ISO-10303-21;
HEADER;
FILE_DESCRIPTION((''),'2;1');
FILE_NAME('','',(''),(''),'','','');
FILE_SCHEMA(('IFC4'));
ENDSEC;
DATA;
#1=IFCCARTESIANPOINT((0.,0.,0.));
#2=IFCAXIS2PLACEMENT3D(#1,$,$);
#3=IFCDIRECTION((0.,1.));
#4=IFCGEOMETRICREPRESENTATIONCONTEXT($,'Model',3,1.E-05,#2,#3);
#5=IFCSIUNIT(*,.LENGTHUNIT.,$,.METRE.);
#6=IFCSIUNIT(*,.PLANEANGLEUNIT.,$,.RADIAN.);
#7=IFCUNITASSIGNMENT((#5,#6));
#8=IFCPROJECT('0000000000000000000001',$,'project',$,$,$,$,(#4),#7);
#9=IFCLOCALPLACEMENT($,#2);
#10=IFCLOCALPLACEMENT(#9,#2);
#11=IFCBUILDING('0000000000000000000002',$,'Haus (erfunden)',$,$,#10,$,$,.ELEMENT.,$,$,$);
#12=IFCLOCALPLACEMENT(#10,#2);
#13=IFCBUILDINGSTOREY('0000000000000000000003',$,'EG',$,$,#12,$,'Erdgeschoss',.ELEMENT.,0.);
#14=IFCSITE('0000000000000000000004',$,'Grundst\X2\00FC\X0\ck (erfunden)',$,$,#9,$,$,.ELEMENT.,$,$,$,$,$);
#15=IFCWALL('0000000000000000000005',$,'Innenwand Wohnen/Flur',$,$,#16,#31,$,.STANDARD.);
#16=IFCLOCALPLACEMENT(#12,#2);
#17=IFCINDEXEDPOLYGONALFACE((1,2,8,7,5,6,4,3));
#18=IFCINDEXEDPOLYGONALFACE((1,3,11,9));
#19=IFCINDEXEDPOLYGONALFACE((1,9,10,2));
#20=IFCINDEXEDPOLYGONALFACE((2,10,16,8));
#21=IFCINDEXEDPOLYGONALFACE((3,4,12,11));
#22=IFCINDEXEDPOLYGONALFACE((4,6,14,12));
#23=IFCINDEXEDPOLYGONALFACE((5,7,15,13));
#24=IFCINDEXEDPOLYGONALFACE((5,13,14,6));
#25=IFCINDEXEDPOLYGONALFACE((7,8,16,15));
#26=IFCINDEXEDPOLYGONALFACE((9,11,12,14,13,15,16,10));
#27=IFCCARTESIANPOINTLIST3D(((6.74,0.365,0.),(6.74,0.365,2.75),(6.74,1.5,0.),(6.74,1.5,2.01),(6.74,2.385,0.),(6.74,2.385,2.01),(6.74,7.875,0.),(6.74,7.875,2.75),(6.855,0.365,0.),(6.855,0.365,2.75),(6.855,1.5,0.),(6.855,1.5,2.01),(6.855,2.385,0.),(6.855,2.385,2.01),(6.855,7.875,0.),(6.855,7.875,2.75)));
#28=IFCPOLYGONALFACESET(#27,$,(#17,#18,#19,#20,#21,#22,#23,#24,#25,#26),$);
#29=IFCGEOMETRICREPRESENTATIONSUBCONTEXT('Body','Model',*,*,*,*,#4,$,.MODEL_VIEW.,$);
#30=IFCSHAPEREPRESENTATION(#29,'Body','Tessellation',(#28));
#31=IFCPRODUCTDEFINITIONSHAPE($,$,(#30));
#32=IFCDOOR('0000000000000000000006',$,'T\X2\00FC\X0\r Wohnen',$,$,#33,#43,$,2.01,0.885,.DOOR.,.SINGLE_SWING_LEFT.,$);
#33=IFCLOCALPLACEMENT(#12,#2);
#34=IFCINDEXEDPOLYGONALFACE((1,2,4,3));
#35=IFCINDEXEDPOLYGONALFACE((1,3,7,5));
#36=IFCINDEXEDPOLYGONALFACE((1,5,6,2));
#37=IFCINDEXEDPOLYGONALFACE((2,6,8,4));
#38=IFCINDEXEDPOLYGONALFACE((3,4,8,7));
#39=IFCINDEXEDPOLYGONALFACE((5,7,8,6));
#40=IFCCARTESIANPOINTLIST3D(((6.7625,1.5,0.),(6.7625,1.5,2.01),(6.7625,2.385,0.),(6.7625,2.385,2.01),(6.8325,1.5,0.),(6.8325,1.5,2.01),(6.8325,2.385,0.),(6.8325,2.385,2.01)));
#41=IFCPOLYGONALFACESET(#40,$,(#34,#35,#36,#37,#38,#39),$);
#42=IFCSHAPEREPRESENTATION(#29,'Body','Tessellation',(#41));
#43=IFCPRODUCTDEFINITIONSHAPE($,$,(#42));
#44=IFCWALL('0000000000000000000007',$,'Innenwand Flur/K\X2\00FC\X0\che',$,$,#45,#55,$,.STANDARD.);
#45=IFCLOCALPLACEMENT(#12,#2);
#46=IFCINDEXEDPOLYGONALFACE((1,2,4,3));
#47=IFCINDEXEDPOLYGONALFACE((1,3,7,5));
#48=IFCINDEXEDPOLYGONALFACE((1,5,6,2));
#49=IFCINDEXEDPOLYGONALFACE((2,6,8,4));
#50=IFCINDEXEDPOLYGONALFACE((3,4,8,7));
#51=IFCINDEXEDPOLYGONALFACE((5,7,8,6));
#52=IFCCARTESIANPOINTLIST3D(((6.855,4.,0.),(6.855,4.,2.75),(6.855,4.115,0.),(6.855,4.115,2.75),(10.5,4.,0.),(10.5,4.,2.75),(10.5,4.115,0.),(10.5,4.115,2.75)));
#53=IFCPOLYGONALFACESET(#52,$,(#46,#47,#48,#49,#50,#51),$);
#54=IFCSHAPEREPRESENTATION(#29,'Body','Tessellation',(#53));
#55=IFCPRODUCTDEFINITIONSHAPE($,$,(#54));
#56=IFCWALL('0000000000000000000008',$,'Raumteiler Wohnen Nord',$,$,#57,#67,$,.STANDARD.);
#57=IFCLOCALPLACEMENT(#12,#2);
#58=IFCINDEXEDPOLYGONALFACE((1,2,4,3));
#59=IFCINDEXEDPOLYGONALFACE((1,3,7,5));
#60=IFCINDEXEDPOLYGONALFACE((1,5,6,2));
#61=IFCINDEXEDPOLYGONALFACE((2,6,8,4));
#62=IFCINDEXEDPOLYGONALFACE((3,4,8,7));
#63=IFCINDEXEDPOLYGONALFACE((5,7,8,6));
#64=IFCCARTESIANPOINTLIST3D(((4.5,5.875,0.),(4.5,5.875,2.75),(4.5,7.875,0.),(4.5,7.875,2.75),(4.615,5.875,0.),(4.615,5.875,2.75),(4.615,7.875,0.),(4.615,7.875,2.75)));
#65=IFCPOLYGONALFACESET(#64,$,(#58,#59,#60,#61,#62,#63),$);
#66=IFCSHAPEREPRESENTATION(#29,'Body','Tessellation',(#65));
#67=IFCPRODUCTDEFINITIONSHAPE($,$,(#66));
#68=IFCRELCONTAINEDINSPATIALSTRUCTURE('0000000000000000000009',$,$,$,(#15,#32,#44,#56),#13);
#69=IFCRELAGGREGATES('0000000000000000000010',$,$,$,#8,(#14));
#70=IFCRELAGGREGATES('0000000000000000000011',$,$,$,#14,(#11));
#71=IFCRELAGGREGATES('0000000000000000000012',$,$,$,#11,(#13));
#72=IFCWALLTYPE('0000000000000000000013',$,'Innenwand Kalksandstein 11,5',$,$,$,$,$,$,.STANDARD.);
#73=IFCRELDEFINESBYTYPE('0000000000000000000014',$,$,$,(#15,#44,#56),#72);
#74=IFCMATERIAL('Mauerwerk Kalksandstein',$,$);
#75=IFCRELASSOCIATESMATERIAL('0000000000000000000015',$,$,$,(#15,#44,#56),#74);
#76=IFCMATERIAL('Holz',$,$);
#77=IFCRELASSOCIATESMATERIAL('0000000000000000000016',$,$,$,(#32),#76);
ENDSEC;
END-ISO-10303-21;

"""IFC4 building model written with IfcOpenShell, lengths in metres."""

from ifc_helpers import new_model, si_unit, direction, frame, frame_2d, origin, place, context, subcontext, project, spatial, rectangle, extrude, material, type_object, element, fill, save


model = new_model("IFC4")

# Units and contexts
model_context = context("Model", 3, precision=1e-05, world=origin(), true_north=direction((0.0, 1.0)))
body_context = subcontext(model_context, "Body", "Model", "MODEL_VIEW")
ifc_project = project(units=[si_unit("LENGTHUNIT", "METRE"), si_unit("PLANEANGLEUNIT", "RADIAN")], contexts=[model_context])

# Site, building, storey
site_placement = place(None, origin())
site = spatial("IfcSite", under=ifc_project, at=site_placement, Name="Grundstück (erfunden)", CompositionType="ELEMENT")
building_placement = place(site_placement, origin())
building = spatial("IfcBuilding", under=site, at=building_placement, Name="Haus (erfunden)", CompositionType="ELEMENT")
storey_placement = place(building_placement, origin())
storey = spatial("IfcBuildingStorey", under=building, at=storey_placement, Name="EG", LongName="Erdgeschoss", CompositionType="ELEMENT", Elevation=0.0)

# Shared definitions
ifc_material_1 = material(Name="Holz")

# Wall, opening, door
ifc_material_2 = material(Name="Mauerwerk Kalksandstein")
wall_type_1 = type_object("IfcWallType", Name="Innenwand Kalksandstein 11,5", PredefinedType="STANDARD")
wall_1_placement = place(storey_placement, frame((6.74, 0.365, 0.0)))
wall_1 = element("IfcWall", 1, at=wall_1_placement, inside=storey, type_object=wall_type_1, material=ifc_material_2, Name="Innenwand Wohnen/Flur", PredefinedType="STANDARD", context=body_context, shape_type="SweptSolid", body=[
    extrude(rectangle(XDim=0.115, YDim=7.51, at=frame_2d((0.0575, 3.755))), origin(), (0.0, 0.0, 1.0), 2.75),
])
opening_1_placement = place(wall_1_placement, frame((-0.05, 1.135, 0.0)))
opening_1 = element("IfcOpeningElement", 2, at=opening_1_placement, cuts=wall_1, PredefinedType="OPENING", context=body_context, shape_type="SweptSolid", body=[
    extrude(rectangle(XDim=0.215, YDim=0.885, at=frame_2d((0.1075, 0.4425))), origin(), (0.0, 0.0, 1.0), 2.01),
])
door_1_placement = place(opening_1_placement, frame((0.0725, 0.0, 0.0)))
door_1 = element("IfcDoor", 3, at=door_1_placement, inside=storey, material=ifc_material_1, Name="Tür Wohnen", OperationType="SINGLE_SWING_LEFT", OverallHeight=2.01, OverallWidth=0.885, PredefinedType="DOOR", context=body_context, shape_type="SweptSolid", body=[
    extrude(rectangle(XDim=0.07, YDim=0.885, at=frame_2d((0.035, 0.4425))), origin(), (0.0, 0.0, 1.0), 2.01),
])
fill(opening_1, door_1)

# Walls
wall_2_placement = place(storey_placement, frame((6.855, 4.0, 0.0)))
element("IfcWall", 4, at=wall_2_placement, inside=storey, type_object=wall_type_1, material=ifc_material_2, Name="Innenwand Flur/Küche", PredefinedType="STANDARD", context=body_context, shape_type="SweptSolid", body=[
    extrude(rectangle(XDim=3.645, YDim=0.115, at=frame_2d((1.8225, 0.0575))), origin(), (0.0, 0.0, 1.0), 2.75),
])
wall_3_placement = place(storey_placement, frame((4.5, 5.875, 0.0)))
element("IfcWall", 5, at=wall_3_placement, inside=storey, type_object=wall_type_1, material=ifc_material_2, Name="Raumteiler Wohnen Nord", PredefinedType="STANDARD", context=body_context, shape_type="SweptSolid", body=[
    extrude(rectangle(XDim=0.115, YDim=2.0, at=frame_2d((0.0575, 1.0))), origin(), (0.0, 0.0, 1.0), 2.75),
])

save(model, "model.ifc")
